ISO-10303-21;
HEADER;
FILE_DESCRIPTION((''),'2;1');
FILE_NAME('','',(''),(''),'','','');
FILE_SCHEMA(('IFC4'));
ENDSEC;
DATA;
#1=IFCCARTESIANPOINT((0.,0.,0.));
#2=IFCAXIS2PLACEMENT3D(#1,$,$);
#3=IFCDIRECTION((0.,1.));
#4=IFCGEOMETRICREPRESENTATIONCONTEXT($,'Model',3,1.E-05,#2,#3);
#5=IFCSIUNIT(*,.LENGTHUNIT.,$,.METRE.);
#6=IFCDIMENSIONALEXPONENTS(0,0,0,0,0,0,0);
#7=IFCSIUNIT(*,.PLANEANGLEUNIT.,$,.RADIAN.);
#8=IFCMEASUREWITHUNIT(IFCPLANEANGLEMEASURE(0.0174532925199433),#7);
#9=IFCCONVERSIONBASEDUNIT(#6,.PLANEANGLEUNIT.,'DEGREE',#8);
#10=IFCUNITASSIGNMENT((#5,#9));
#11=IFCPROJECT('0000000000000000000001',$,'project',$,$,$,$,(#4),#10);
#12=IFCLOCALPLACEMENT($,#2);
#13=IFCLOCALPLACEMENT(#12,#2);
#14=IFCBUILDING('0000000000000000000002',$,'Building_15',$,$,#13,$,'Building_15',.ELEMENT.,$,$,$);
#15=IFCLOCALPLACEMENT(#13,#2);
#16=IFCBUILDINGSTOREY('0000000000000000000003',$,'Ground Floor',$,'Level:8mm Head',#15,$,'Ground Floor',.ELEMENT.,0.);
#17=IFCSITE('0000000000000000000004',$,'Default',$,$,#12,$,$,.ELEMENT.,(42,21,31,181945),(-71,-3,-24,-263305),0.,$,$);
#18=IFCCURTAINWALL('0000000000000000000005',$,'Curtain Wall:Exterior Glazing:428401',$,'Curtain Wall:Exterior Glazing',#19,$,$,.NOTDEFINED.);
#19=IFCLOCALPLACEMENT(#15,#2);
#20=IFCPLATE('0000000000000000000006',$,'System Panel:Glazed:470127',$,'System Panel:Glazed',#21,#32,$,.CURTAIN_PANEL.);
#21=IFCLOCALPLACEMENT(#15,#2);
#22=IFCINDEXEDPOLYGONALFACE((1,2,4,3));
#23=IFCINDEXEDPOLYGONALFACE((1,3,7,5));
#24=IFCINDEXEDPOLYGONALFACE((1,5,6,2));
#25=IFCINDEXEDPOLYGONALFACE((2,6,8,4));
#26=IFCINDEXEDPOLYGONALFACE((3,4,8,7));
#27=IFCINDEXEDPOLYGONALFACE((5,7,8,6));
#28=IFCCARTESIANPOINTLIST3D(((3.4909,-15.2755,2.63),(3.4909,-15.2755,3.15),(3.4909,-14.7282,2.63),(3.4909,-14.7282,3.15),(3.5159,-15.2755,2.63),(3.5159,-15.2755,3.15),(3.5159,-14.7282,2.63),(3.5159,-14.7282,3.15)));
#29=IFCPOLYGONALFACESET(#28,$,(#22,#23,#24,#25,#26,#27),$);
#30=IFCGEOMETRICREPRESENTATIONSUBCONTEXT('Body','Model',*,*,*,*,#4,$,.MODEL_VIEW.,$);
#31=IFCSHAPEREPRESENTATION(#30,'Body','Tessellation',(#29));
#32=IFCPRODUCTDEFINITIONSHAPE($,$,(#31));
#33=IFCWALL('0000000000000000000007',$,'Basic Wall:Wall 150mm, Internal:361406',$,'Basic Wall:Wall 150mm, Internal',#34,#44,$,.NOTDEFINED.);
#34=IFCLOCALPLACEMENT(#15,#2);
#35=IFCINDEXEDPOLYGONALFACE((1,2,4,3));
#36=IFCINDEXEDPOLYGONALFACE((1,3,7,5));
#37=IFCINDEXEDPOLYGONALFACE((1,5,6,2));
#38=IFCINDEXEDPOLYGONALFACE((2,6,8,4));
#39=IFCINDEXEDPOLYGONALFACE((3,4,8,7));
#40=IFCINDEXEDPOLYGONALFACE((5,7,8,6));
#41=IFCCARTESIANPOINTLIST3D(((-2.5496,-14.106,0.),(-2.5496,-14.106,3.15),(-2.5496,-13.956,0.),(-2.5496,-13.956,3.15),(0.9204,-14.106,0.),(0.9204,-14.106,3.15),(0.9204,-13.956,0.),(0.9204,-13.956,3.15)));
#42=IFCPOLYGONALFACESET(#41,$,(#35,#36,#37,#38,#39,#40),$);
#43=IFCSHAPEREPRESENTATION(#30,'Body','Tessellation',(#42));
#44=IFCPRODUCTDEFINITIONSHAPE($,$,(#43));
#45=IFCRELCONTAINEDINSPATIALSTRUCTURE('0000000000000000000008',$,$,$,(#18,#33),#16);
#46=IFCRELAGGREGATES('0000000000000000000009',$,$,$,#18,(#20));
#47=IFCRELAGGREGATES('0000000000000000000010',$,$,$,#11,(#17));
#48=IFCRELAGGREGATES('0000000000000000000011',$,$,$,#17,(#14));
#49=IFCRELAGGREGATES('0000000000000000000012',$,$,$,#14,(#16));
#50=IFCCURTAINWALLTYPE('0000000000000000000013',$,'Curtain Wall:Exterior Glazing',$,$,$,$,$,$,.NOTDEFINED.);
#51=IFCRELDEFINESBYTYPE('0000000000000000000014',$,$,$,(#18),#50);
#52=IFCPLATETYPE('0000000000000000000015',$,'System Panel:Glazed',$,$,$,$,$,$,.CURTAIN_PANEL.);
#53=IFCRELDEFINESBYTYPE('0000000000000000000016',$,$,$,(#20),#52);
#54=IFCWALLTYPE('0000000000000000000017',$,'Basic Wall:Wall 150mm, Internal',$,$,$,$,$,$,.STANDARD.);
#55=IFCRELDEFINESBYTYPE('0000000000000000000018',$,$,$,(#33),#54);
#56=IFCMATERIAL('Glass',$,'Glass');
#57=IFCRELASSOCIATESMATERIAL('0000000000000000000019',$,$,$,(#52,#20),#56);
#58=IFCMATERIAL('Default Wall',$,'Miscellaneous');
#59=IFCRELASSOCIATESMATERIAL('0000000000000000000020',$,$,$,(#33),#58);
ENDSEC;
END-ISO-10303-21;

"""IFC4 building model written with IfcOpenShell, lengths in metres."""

from ifc_helpers import new_model, entity, si_unit, converted_unit, direction, frame, origin, place, context, subcontext, project, spatial, indexed_curve, outline, extrude, source, transform, mapped, material, type_object, type_shapes, element, aggregate, save


model = new_model("IFC4")

# Units and contexts
model_context = context("Model", 3, precision=1e-05, world=origin(), true_north=direction((0.0, 1.0)))
body_context = subcontext(model_context, "Body", "Model", "MODEL_VIEW")
ifc_project = project(units=[si_unit("LENGTHUNIT", "METRE"), converted_unit("PLANEANGLEUNIT", "DEGREE", entity("IfcPlaneAngleMeasure", 0.0174532925199433), si_unit("PLANEANGLEUNIT", "RADIAN"), dimensions=[0, 0, 0, 0, 0, 0, 0])], contexts=[model_context])

# Site, building, storey
site_placement = place(None, origin())
site = spatial("IfcSite", under=ifc_project, at=site_placement, Name="Default", CompositionType="ELEMENT", RefLatitude=(42, 21, 31, 181945), RefLongitude=(-71, -3, -24, -263305), RefElevation=0.0)
building_placement = place(site_placement, origin())
building = spatial("IfcBuilding", under=site, at=building_placement, Name="Building_15", LongName="Building_15", CompositionType="ELEMENT")
storey_placement = place(building_placement, origin())
storey = spatial("IfcBuildingStorey", under=building, at=storey_placement, Name="Ground Floor", ObjectType="Level:8mm Head", LongName="Ground Floor", CompositionType="ELEMENT", Elevation=0.0)

# Curtain wall, plate
curtain_wall_type = type_object("IfcCurtainWallType", Name="Curtain Wall:Exterior Glazing", PredefinedType="NOTDEFINED")
curtain_wall_placement = place(storey_placement, origin())
curtain_wall = element("IfcCurtainWall", 1, at=curtain_wall_placement, inside=storey, type_object=curtain_wall_type, Name="Curtain Wall:Exterior Glazing:428401", ObjectType="Curtain Wall:Exterior Glazing", PredefinedType="NOTDEFINED")
ifc_material_1 = material(Name="Glass", Category="Glass")
plate_type_1 = type_object("IfcPlateType", Name="System Panel:Glazed", PredefinedType="CURTAIN_PANEL", material=ifc_material_1)
shared_shape_1 = source(origin(), body_context, "Body", "SweptSolid", [
    extrude(outline(indexed_curve([(-0.0125, -0.2736), (0.0125, -0.2736), (0.0125, 0.2736), (-0.0125, 0.2736), (-0.0125, -0.2736)], self_intersect=False)), frame((0.0, 0.037, 0.0), z_axis=(0.0, 0.0, 1.0), x_axis=(0.0, 1.0, 0.0)), (0.0, 0.0, 1.0), 0.52),
])
type_shapes(plate_type_1, [shared_shape_1])
plate_1_placement = place(curtain_wall_placement, frame((3.5404, -15.0018, 2.63), z_axis=(0.0, 0.0, 1.0), x_axis=(0.0, 1.0, 0.0)))
plate_1 = element("IfcPlate", 2, at=plate_1_placement, type_object=plate_type_1, material=ifc_material_1, Name="System Panel:Glazed:470127", ObjectType="System Panel:Glazed", PredefinedType="CURTAIN_PANEL", context=body_context, shape_type="MappedRepresentation", body=[
    mapped(shared_shape_1, transform((0.0, 0.0, 0.0), scale=1.0)),
])
aggregate(curtain_wall, [plate_1])

# Wall
ifc_material_2 = material(Name="Default Wall", Category="Miscellaneous")
wall_type = type_object("IfcWallType", Name="Basic Wall:Wall 150mm, Internal", PredefinedType="STANDARD")
wall_placement = place(storey_placement, frame((-2.5496, -14.031, 0.0)))
element("IfcWall", 3, at=wall_placement, inside=storey, type_object=wall_type, material=ifc_material_2, Name="Basic Wall:Wall 150mm, Internal:361406", ObjectType="Basic Wall:Wall 150mm, Internal", PredefinedType="NOTDEFINED", context=body_context, shape_type="SweptSolid", body=[
    extrude(outline(indexed_curve([(3.47, 0.075), (0.0, 0.075), (0.0, -0.075), (3.47, -0.075), (3.47, 0.075)], self_intersect=False)), origin(), (0.0, 0.0, 1.0), 3.15),
])

save(model, "model.ifc")
